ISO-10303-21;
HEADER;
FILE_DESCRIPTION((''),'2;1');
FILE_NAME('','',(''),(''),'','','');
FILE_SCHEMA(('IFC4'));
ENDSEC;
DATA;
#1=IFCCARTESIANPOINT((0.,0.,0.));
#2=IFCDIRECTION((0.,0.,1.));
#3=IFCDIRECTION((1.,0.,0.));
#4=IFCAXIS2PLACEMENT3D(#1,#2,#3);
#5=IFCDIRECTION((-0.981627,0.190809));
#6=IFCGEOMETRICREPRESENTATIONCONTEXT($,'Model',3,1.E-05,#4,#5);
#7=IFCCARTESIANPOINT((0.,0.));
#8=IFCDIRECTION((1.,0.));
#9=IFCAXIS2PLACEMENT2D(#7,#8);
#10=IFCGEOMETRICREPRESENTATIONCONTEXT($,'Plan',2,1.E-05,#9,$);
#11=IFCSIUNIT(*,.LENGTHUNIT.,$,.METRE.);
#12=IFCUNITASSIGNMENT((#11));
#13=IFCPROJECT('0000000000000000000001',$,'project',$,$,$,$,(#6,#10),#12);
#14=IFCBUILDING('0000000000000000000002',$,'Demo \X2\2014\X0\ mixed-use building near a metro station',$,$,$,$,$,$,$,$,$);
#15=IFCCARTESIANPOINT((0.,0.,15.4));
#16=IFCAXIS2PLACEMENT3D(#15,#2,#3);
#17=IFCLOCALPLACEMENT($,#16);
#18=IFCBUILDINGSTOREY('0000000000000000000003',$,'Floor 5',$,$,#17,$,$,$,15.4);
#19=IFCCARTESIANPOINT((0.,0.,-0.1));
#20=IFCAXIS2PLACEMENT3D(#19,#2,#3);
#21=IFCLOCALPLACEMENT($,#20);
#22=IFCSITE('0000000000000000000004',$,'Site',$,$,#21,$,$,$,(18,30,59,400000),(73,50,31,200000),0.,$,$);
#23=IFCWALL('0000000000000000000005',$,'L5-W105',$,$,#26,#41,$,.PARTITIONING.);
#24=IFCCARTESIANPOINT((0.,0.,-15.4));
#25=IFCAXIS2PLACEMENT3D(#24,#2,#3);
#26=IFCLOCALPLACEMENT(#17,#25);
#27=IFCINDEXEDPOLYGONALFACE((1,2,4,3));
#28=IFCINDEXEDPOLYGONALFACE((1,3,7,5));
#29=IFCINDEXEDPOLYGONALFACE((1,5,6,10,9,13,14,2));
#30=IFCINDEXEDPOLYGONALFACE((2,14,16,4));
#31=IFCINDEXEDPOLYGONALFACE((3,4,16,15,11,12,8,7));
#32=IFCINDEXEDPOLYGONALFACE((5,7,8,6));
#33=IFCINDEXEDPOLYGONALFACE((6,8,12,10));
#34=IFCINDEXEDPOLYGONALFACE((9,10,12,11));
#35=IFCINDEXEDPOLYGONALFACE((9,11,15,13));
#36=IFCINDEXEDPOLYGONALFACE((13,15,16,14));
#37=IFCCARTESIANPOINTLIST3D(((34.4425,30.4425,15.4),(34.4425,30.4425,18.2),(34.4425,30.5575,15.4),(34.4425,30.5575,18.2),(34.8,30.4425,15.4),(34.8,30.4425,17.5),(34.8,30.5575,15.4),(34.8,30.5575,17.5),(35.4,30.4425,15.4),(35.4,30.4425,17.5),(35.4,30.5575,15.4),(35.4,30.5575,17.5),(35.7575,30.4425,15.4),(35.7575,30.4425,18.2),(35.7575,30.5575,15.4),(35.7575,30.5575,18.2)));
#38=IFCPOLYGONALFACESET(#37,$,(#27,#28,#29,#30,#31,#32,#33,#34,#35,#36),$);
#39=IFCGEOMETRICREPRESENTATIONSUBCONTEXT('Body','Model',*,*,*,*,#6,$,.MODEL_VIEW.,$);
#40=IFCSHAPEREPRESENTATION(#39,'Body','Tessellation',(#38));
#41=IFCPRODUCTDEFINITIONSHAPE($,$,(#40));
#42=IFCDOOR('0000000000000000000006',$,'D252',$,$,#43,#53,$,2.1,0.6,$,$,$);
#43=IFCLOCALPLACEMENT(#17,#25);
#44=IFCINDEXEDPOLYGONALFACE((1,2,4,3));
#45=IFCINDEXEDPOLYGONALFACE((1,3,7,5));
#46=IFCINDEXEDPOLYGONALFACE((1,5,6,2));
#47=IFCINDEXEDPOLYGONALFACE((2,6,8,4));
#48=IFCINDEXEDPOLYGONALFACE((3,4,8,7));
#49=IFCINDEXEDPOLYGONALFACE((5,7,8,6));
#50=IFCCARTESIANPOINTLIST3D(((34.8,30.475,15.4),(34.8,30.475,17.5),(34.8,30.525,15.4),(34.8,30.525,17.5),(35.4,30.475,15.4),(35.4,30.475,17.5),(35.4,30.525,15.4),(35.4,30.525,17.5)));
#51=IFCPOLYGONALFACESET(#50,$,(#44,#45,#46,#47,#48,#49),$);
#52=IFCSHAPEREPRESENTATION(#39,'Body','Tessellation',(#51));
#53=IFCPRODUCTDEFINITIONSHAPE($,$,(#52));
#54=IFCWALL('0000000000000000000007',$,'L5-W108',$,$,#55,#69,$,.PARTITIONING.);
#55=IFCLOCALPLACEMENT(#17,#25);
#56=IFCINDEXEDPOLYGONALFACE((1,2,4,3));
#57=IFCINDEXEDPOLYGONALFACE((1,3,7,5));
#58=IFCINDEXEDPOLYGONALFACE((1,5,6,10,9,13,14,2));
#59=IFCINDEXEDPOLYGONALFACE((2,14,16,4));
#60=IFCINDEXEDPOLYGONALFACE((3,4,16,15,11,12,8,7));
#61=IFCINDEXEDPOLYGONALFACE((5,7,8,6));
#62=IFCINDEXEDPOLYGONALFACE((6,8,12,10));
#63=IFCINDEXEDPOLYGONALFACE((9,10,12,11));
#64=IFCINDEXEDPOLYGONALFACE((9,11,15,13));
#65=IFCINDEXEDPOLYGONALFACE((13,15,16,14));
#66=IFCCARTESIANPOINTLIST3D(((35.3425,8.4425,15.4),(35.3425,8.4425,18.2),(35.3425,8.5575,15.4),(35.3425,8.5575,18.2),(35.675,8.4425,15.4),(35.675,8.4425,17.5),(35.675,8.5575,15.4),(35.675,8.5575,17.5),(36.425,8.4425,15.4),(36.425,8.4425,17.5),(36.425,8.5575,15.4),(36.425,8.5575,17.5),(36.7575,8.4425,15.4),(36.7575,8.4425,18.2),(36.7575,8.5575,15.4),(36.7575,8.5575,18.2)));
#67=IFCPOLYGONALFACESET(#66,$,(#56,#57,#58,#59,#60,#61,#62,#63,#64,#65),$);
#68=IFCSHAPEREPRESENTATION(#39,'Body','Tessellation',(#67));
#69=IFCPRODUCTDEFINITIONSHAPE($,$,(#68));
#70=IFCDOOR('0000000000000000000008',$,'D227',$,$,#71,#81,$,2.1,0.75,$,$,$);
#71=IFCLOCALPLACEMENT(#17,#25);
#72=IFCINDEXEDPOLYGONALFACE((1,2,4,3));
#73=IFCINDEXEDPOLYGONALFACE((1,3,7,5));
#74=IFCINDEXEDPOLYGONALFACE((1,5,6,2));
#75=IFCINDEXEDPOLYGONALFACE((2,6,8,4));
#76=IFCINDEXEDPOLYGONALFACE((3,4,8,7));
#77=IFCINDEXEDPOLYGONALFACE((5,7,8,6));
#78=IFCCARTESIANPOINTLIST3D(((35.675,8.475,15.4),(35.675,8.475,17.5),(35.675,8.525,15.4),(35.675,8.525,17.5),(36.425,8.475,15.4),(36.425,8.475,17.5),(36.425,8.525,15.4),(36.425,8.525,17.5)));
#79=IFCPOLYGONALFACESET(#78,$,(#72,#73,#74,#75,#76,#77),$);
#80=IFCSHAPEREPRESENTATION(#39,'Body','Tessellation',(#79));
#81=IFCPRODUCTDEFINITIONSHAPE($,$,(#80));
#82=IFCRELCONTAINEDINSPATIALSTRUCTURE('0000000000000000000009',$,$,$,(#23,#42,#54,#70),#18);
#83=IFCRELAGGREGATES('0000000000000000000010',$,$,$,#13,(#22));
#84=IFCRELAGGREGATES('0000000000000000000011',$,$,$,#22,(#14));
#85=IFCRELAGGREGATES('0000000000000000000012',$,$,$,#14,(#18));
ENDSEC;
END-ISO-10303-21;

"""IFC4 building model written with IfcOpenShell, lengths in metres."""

from ifc_helpers import new_model, si_unit, direction, frame, origin_with_axes, origin_2d_with_axis, place, context, subcontext, project, spatial, line, indexed_curve, outline, extrude, element, fill, save


model = new_model("IFC4")

# Units and contexts
model_context = context("Model", 3, precision=1e-05, world=origin_with_axes(), true_north=direction((-0.981627, 0.190809)))
plan_context = context("Plan", 2, precision=1e-05, world=origin_2d_with_axis())
body_context = subcontext(model_context, "Body", "Model", "MODEL_VIEW")
ifc_project = project(units=[si_unit("LENGTHUNIT", "METRE")], contexts=[model_context, plan_context])

# Site, building, storey
site_placement = place(None, frame((0.0, 0.0, -0.1), z_axis=(0.0, 0.0, 1.0), x_axis=(1.0, 0.0, 0.0)))
site = spatial("IfcSite", under=ifc_project, at=site_placement, Name="Site", RefLatitude=(18, 30, 59, 400000), RefLongitude=(73, 50, 31, 200000), RefElevation=0.0)
building = spatial("IfcBuilding", under=site, Name="Demo — mixed-use building near a metro station")
storey_placement = place(None, frame((0.0, 0.0, 15.4), z_axis=(0.0, 0.0, 1.0), x_axis=(1.0, 0.0, 0.0)))
storey = spatial("IfcBuildingStorey", under=building, at=storey_placement, Name="Floor 5", Elevation=15.4)

# Wall, opening, door
wall_1_placement = place(storey_placement, frame((0.0, 0.0, -15.4), z_axis=(0.0, 0.0, 1.0), x_axis=(1.0, 0.0, 0.0)))
wall_1 = element("IfcWall", 1, at=wall_1_placement, inside=storey, Name="L5-W105", PredefinedType="PARTITIONING", context=body_context, shape_type="SweptSolid", body=[
    extrude(outline(indexed_curve([(35.7575, 30.4425), (34.4425, 30.4425), (34.4425, 30.5575), (35.7575, 30.5575)], segments=[line(1, 2, 3, 4, 1)])), frame((0.0, 0.0, 15.4), z_axis=(0.0, 0.0, 1.0), x_axis=(1.0, 0.0, 0.0)), (0.0, 0.0, 1.0), 2.8),
])
opening_1_placement = place(wall_1_placement, origin_with_axes())
opening_1 = element("IfcOpeningElement", 2, at=opening_1_placement, cuts=wall_1, context=body_context, shape_type="SweptSolid", body=[
    extrude(outline(indexed_curve([(35.4, 30.3925), (34.8, 30.3925), (34.8, 30.6075), (35.4, 30.6075)], segments=[line(1, 2, 3, 4, 1)])), frame((0.0, 0.0, 15.4), z_axis=(0.0, 0.0, 1.0), x_axis=(1.0, 0.0, 0.0)), (0.0, 0.0, 1.0), 2.1),
])
door_1_placement = place(storey_placement, frame((0.0, 0.0, -15.4), z_axis=(0.0, 0.0, 1.0), x_axis=(1.0, 0.0, 0.0)))
door_1 = element("IfcDoor", 3, at=door_1_placement, inside=storey, Name="D252", OverallHeight=2.1, OverallWidth=0.6, context=body_context, shape_type="SweptSolid", body=[
    extrude(outline(indexed_curve([(35.4, 30.475), (34.8, 30.475), (34.8, 30.525), (35.4, 30.525)], segments=[line(1, 2, 3, 4, 1)])), frame((0.0, 0.0, 15.4), z_axis=(0.0, 0.0, 1.0), x_axis=(1.0, 0.0, 0.0)), (0.0, 0.0, 1.0), 2.1),
])
fill(opening_1, door_1)

# Wall, opening, door
wall_2_placement = place(storey_placement, frame((0.0, 0.0, -15.4), z_axis=(0.0, 0.0, 1.0), x_axis=(1.0, 0.0, 0.0)))
wall_2 = element("IfcWall", 4, at=wall_2_placement, inside=storey, Name="L5-W108", PredefinedType="PARTITIONING", context=body_context, shape_type="SweptSolid", body=[
    extrude(outline(indexed_curve([(36.7575, 8.4425), (35.3425, 8.4425), (35.3425, 8.5575), (36.7575, 8.5575)], segments=[line(1, 2, 3, 4, 1)])), frame((0.0, 0.0, 15.4), z_axis=(0.0, 0.0, 1.0), x_axis=(1.0, 0.0, 0.0)), (0.0, 0.0, 1.0), 2.8),
])
opening_2_placement = place(wall_2_placement, origin_with_axes())
opening_2 = element("IfcOpeningElement", 5, at=opening_2_placement, cuts=wall_2, context=body_context, shape_type="SweptSolid", body=[
    extrude(outline(indexed_curve([(36.425, 8.3925), (35.675, 8.3925), (35.675, 8.6075), (36.425, 8.6075)], segments=[line(1, 2, 3, 4, 1)])), frame((0.0, 0.0, 15.4), z_axis=(0.0, 0.0, 1.0), x_axis=(1.0, 0.0, 0.0)), (0.0, 0.0, 1.0), 2.1),
])
door_2_placement = place(storey_placement, frame((0.0, 0.0, -15.4), z_axis=(0.0, 0.0, 1.0), x_axis=(1.0, 0.0, 0.0)))
door_2 = element("IfcDoor", 6, at=door_2_placement, inside=storey, Name="D227", OverallHeight=2.1, OverallWidth=0.75, context=body_context, shape_type="SweptSolid", body=[
    extrude(outline(indexed_curve([(36.425, 8.475), (35.675, 8.475), (35.675, 8.525), (36.425, 8.525)], segments=[line(1, 2, 3, 4, 1)])), frame((0.0, 0.0, 15.4), z_axis=(0.0, 0.0, 1.0), x_axis=(1.0, 0.0, 0.0)), (0.0, 0.0, 1.0), 2.1),
])
fill(opening_2, door_2)

save(model, "model.ifc")
